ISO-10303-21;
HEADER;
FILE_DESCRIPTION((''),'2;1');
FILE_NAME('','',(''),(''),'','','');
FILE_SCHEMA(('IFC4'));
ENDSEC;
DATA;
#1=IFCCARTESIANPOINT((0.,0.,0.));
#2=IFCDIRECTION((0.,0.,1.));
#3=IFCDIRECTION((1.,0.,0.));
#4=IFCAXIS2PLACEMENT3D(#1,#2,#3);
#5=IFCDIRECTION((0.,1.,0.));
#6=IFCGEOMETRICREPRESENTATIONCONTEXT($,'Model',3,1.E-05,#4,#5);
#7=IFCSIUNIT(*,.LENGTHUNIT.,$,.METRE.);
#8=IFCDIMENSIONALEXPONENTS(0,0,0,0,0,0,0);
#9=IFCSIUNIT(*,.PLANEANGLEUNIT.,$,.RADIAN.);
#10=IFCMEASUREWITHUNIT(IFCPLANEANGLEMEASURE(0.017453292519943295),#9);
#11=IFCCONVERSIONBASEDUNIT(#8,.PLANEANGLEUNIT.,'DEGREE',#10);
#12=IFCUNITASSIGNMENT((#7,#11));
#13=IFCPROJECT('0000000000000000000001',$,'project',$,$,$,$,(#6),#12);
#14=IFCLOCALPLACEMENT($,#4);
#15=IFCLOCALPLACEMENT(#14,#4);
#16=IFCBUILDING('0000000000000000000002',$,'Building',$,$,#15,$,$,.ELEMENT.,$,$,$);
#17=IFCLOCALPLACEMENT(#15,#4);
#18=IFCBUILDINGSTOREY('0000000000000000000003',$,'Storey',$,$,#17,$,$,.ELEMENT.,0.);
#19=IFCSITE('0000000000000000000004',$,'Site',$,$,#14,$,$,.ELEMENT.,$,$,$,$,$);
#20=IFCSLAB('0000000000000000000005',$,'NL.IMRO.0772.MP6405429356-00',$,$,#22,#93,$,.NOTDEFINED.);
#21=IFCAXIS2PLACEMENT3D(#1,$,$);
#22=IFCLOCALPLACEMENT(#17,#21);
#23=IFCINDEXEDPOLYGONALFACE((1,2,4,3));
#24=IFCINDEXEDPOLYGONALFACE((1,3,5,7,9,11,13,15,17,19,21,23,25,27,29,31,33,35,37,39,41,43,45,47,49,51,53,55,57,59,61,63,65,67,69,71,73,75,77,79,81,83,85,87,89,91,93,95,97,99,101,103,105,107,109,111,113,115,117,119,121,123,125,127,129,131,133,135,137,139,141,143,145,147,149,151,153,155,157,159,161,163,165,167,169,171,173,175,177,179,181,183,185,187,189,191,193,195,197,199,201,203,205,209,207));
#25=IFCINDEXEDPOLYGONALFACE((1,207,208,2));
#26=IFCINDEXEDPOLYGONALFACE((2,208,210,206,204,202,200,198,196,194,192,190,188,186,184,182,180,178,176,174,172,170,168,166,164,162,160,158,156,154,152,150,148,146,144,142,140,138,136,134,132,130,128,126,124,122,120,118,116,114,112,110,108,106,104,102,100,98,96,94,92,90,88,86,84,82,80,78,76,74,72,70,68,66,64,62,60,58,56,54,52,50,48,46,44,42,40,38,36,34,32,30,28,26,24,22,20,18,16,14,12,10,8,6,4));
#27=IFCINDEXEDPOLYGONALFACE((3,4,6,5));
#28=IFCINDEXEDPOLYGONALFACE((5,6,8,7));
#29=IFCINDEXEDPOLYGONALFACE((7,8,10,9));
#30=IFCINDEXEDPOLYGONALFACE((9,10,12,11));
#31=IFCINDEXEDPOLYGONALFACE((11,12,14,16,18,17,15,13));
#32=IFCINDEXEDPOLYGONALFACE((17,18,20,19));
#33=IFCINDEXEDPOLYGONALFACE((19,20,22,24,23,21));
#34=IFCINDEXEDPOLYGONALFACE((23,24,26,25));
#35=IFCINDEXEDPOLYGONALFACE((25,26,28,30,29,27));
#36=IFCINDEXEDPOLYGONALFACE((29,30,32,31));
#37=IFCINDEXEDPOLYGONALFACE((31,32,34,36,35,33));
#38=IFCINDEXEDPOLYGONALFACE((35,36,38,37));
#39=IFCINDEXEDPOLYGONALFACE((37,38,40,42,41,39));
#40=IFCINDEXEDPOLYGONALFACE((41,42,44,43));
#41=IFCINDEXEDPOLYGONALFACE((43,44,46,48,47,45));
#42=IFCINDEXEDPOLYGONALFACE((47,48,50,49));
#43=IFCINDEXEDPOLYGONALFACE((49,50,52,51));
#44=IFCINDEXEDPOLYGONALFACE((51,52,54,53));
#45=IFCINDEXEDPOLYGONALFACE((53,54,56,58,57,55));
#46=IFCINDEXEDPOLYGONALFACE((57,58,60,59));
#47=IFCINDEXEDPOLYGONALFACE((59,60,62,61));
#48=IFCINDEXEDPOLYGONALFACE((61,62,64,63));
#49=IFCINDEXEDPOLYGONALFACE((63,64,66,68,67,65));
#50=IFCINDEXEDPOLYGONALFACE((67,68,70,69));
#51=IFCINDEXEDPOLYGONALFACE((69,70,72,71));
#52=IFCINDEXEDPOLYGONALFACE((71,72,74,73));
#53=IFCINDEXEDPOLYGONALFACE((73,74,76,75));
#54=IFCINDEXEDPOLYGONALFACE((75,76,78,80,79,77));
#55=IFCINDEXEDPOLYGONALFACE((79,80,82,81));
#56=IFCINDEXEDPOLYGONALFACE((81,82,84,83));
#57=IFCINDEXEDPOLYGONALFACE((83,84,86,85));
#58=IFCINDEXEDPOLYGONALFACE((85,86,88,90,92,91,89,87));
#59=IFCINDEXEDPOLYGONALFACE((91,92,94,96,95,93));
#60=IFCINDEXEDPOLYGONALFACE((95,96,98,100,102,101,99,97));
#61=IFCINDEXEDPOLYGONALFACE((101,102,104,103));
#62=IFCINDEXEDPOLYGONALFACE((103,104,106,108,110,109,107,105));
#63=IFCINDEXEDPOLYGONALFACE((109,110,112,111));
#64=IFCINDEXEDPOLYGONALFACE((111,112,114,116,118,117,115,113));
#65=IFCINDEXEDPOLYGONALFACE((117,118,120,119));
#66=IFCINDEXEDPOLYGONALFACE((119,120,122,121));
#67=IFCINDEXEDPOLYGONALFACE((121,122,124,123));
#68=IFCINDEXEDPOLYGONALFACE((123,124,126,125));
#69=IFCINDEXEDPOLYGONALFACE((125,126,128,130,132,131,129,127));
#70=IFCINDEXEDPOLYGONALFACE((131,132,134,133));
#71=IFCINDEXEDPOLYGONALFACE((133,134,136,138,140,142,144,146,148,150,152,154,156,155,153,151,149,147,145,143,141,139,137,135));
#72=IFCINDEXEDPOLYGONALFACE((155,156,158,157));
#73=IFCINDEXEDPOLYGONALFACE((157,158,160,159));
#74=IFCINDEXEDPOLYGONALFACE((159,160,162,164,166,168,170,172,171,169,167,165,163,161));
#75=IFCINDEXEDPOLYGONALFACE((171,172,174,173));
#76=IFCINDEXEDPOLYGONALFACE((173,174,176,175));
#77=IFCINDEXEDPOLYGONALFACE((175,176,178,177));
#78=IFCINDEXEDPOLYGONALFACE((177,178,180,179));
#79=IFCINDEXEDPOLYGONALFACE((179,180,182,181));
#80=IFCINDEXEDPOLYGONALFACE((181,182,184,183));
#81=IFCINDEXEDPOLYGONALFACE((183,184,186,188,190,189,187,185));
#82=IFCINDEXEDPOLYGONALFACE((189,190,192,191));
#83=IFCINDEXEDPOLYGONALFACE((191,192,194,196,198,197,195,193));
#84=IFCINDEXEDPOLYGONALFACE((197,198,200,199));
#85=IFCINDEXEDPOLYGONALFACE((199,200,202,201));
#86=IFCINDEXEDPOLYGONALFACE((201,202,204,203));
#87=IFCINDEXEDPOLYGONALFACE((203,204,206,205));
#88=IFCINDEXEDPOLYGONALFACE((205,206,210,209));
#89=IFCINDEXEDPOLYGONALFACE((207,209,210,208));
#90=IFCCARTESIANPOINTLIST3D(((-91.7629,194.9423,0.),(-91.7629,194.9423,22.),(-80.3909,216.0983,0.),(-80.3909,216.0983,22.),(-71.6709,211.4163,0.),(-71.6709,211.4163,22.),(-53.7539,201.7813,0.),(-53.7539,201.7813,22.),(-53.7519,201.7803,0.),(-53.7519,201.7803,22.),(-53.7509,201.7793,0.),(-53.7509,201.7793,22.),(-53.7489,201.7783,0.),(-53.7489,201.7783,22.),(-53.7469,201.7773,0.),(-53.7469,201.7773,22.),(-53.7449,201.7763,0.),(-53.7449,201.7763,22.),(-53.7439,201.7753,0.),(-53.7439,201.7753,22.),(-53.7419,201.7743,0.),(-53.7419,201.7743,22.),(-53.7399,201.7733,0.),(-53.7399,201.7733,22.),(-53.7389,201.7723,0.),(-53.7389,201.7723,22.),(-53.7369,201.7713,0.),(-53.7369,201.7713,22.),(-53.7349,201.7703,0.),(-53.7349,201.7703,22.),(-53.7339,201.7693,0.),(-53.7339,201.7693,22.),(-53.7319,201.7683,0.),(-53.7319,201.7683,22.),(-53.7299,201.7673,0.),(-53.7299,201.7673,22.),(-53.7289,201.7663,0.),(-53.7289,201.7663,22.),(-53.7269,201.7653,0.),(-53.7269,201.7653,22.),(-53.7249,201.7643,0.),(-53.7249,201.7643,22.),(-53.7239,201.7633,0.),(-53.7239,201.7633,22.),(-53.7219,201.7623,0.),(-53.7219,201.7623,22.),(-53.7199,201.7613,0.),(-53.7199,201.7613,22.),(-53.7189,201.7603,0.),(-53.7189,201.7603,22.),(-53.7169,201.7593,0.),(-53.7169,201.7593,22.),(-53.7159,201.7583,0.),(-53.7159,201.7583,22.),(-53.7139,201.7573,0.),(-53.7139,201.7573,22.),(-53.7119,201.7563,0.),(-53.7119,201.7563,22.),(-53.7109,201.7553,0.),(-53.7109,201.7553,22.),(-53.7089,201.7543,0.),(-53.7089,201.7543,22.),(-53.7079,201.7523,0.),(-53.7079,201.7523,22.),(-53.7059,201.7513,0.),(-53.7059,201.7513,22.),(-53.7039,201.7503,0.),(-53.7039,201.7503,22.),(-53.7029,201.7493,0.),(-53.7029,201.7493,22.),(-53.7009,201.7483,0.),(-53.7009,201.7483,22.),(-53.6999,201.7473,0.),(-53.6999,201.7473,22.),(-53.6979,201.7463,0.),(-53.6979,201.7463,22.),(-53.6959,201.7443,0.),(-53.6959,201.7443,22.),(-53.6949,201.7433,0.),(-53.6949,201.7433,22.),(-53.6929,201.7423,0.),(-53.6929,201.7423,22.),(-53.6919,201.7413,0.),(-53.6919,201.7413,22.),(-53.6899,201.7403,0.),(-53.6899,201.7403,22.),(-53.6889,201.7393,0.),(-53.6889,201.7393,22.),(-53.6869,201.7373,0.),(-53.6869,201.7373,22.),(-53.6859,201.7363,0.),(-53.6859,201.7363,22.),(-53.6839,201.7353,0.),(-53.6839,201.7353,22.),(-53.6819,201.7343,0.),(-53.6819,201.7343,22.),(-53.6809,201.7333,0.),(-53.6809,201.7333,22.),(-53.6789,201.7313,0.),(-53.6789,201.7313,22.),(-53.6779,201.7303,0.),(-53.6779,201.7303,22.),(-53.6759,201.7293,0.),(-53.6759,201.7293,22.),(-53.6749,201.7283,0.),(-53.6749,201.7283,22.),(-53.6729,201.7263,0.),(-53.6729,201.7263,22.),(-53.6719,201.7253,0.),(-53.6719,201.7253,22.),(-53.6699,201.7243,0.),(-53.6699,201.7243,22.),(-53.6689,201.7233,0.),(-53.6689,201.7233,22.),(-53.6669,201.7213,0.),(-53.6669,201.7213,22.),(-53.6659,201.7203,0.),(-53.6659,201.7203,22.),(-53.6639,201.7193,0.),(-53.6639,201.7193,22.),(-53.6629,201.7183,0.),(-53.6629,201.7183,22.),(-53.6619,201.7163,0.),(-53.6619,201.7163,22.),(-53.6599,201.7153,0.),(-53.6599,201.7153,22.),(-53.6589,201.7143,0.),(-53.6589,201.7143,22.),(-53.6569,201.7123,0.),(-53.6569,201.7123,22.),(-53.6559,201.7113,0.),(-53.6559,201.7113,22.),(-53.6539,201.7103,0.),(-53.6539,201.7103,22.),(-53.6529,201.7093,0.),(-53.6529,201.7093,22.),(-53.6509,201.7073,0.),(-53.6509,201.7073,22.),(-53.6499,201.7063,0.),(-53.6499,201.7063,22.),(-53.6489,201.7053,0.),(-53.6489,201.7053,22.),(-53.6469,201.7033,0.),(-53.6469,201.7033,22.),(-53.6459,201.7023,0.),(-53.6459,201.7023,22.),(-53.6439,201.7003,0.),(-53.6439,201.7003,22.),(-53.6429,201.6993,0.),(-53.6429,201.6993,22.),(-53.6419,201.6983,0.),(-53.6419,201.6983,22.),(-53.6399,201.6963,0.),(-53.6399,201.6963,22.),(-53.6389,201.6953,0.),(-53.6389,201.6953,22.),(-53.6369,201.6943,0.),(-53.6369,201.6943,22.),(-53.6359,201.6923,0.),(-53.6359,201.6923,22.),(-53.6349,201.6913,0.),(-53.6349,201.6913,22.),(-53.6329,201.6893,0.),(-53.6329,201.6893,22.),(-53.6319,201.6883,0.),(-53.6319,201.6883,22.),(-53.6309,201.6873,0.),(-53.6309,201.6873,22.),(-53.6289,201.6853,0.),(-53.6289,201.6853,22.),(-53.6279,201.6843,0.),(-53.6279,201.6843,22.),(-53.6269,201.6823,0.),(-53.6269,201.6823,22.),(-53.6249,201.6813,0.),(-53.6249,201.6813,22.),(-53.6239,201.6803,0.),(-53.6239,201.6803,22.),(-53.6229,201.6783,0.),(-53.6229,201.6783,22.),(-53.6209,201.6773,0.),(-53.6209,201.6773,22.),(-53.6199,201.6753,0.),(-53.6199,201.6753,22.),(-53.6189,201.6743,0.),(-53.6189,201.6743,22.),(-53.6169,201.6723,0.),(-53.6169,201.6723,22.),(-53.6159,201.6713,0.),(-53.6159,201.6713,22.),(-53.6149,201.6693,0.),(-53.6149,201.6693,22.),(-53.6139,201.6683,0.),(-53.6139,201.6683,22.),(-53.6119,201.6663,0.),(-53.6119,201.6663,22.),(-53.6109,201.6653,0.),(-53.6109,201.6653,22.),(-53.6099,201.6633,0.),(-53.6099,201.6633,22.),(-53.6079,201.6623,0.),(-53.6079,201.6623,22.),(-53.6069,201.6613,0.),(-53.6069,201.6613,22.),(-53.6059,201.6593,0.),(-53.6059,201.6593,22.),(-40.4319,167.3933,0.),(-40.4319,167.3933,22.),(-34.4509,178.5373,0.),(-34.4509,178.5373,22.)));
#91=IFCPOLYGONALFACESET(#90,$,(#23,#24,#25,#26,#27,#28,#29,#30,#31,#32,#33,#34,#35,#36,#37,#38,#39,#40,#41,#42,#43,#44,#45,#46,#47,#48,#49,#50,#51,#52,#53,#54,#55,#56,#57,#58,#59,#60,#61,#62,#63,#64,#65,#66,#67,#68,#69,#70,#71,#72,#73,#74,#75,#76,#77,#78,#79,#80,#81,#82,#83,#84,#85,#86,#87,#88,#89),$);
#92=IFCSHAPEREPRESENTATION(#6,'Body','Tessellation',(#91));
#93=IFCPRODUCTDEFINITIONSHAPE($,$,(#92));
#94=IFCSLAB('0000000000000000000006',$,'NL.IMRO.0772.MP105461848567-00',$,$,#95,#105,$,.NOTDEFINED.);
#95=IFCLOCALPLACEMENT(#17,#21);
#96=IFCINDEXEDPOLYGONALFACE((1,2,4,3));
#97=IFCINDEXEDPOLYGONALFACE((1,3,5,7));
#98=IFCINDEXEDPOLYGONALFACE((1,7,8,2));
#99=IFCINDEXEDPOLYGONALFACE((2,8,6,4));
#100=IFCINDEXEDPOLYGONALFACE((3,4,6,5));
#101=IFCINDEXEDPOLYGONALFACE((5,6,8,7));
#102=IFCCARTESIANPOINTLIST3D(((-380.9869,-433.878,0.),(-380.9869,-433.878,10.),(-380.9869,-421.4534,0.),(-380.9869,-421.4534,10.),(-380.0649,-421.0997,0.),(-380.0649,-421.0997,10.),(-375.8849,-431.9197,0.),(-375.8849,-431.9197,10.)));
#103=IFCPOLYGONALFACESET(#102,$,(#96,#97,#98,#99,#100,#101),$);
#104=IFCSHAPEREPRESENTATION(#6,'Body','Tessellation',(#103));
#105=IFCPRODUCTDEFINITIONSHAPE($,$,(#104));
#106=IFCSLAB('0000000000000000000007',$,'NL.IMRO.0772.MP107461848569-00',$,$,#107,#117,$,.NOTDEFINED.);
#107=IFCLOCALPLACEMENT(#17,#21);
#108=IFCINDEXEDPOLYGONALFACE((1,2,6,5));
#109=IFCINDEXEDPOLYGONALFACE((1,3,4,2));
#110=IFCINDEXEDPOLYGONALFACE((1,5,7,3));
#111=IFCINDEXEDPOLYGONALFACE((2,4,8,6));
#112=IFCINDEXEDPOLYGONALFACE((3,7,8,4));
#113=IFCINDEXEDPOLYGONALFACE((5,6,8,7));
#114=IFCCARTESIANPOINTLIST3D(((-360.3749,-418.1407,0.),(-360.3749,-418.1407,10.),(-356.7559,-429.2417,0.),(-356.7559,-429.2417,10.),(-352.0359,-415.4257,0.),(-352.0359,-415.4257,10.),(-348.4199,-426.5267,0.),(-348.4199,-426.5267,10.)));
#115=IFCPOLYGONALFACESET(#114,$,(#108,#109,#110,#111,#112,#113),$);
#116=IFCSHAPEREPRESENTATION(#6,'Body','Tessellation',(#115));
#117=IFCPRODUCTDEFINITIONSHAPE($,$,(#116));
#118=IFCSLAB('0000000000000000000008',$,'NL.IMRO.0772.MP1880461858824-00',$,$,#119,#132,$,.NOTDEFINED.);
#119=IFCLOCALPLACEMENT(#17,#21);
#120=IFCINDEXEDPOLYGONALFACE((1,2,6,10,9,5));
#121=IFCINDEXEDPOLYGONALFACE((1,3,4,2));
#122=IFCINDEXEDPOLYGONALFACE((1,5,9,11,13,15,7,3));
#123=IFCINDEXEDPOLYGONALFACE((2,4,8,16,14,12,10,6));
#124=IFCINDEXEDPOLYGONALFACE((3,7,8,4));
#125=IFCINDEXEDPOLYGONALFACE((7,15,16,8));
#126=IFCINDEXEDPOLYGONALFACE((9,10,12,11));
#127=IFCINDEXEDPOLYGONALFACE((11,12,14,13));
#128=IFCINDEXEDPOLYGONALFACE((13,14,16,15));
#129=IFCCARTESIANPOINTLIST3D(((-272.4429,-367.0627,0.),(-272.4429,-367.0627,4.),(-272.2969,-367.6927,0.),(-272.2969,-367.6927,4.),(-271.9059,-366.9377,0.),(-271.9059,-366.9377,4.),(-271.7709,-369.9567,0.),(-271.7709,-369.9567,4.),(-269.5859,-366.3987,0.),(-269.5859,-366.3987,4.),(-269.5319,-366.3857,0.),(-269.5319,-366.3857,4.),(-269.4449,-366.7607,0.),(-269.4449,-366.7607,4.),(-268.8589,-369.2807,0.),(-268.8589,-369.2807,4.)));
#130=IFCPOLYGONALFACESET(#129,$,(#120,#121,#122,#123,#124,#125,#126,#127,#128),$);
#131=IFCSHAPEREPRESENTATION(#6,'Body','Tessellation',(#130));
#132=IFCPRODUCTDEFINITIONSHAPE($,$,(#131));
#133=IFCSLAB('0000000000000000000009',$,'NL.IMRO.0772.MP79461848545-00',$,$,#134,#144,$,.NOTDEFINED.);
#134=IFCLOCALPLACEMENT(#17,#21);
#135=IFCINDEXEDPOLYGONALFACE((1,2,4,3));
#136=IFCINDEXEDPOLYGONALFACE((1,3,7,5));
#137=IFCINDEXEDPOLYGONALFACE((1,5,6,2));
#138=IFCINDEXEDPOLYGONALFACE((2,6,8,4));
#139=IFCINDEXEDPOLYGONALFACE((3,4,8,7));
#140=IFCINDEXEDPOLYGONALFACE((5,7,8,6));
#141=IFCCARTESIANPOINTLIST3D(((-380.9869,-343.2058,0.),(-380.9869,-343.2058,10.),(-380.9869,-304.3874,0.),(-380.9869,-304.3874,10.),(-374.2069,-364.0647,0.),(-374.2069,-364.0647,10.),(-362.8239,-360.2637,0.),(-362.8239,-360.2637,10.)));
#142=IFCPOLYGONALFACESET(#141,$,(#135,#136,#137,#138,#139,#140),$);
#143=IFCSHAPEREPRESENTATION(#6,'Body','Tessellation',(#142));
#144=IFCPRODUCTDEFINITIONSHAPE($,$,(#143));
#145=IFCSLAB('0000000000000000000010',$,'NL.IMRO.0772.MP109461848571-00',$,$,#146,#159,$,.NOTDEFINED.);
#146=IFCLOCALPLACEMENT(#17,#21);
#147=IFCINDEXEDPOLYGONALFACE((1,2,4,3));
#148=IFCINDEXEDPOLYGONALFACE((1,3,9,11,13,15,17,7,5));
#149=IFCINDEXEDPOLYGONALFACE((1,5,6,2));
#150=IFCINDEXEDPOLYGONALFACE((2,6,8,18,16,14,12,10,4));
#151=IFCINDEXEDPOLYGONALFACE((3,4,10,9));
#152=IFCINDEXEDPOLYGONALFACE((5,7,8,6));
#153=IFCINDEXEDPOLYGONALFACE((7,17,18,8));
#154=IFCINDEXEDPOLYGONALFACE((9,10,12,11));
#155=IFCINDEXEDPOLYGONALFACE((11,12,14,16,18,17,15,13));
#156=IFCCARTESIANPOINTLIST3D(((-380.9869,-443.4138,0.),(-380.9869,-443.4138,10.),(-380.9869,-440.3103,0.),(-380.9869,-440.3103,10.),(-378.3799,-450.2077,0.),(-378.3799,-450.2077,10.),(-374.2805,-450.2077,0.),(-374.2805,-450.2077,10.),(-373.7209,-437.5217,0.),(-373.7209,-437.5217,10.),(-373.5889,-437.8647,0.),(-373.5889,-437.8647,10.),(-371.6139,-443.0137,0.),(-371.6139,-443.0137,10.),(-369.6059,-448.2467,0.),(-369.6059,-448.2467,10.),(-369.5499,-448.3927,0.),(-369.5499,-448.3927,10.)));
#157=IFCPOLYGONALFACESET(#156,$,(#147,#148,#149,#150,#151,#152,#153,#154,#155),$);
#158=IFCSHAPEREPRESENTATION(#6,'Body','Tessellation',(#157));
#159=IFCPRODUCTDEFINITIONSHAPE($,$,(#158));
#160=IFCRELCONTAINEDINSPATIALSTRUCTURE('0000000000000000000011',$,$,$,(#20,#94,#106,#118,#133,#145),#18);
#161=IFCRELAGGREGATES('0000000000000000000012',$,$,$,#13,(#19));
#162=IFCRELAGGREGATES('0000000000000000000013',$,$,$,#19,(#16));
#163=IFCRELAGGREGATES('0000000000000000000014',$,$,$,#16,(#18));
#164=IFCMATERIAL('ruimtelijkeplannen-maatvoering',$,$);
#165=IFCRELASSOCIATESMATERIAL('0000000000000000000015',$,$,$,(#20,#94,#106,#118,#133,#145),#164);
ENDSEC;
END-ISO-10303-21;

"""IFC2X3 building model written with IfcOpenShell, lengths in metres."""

from ifc_helpers import new_model, entity, si_unit, converted_unit, direction, origin_with_axes, place, context, project, spatial, polyline, outline, extrude, material, element, save


model = new_model("IFC2X3")

# Units and contexts
model_context = context("Model", 3, precision=1e-05, world=origin_with_axes(), true_north=direction((0.0, 1.0, 0.0)))
ifc_project = project(units=[si_unit("LENGTHUNIT", "METRE"), converted_unit("PLANEANGLEUNIT", "DEGREE", entity("IfcPlaneAngleMeasure", 0.017453292519943295), si_unit("PLANEANGLEUNIT", "RADIAN"), dimensions=[0, 0, 0, 0, 0, 0, 0])], contexts=[model_context])

# Site, building, storey
site_placement = place(None, origin_with_axes())
site = spatial("IfcSite", under=ifc_project, at=site_placement, Name="Site", CompositionType="ELEMENT")
building_placement = place(site_placement, origin_with_axes())
building = spatial("IfcBuilding", under=site, at=building_placement, Name="Building", CompositionType="ELEMENT")
storey_placement = place(building_placement, origin_with_axes())
storey = spatial("IfcBuildingStorey", under=building, at=storey_placement, Name="Storey", CompositionType="ELEMENT", Elevation=0.0)

# Slabs
ifc_material_1 = material(Name="ruimtelijkeplannen-maatvoering")
slab_1_placement = place(storey_placement, origin_with_axes())
element("IfcSlab", 1, at=slab_1_placement, inside=storey, material=ifc_material_1, Name="NL.IMRO.0772.MP6405429356-00", PredefinedType="NOTDEFINED", context=model_context, shape_type="SweptSolid", body=[
    extrude(outline(polyline([(-53.7519, 201.7803), (-53.7509, 201.7793), (-53.7489, 201.7783), (-53.7469, 201.7773), (-53.7449, 201.7763), (-53.7439, 201.7753), (-53.7419, 201.7743), (-53.7399, 201.7733), (-53.7389, 201.7723), (-53.7369, 201.7713), (-53.7349, 201.7703), (-53.7339, 201.7693), (-53.7319, 201.7683), (-53.7299, 201.7673), (-53.7289, 201.7663), (-53.7269, 201.7653), (-53.7249, 201.7643), (-53.7239, 201.7633), (-53.7219, 201.7623), (-53.7199, 201.7613), (-53.7189, 201.7603), (-53.7169, 201.7593), (-53.7159, 201.7583), (-53.7139, 201.7573), (-53.7119, 201.7563), (-53.7109, 201.7553), (-53.7089, 201.7543), (-53.7079, 201.7523), (-53.7059, 201.7513), (-53.7039, 201.7503), (-53.7029, 201.7493), (-53.7009, 201.7483), (-53.6999, 201.7473), (-53.6979, 201.7463), (-53.6959, 201.7443), (-53.6949, 201.7433), (-53.6929, 201.7423), (-53.6919, 201.7413), (-53.6899, 201.7403), (-53.6889, 201.7393), (-53.6869, 201.7373), (-53.6859, 201.7363), (-53.6839, 201.7353), (-53.6819, 201.7343), (-53.6809, 201.7333), (-53.6789, 201.7313), (-53.6779, 201.7303), (-53.6759, 201.7293), (-53.6749, 201.7283), (-53.6729, 201.7263), (-53.6719, 201.7253), (-53.6699, 201.7243), (-53.6689, 201.7233), (-53.6669, 201.7213), (-53.6659, 201.7203), (-53.6639, 201.7193), (-53.6629, 201.7183), (-53.6619, 201.7163), (-53.6599, 201.7153), (-53.6589, 201.7143), (-53.6569, 201.7123), (-53.6559, 201.7113), (-53.6539, 201.7103), (-53.6529, 201.7093), (-53.6509, 201.7073), (-53.6499, 201.7063), (-53.6489, 201.7053), (-53.6469, 201.7033), (-53.6459, 201.7023), (-53.6439, 201.7003), (-53.6429, 201.6993), (-53.6419, 201.6983), (-53.6399, 201.6963), (-53.6389, 201.6953), (-53.6369, 201.6943), (-53.6359, 201.6923), (-53.6349, 201.6913), (-53.6329, 201.6893), (-53.6319, 201.6883), (-53.6309, 201.6873), (-53.6289, 201.6853), (-53.6279, 201.6843), (-53.6269, 201.6823), (-53.6249, 201.6813), (-53.6239, 201.6803), (-53.6229, 201.6783), (-53.6209, 201.6773), (-53.6199, 201.6753), (-53.6189, 201.6743), (-53.6169, 201.6723), (-53.6159, 201.6713), (-53.6149, 201.6693), (-53.6139, 201.6683), (-53.6119, 201.6663), (-53.6109, 201.6653), (-53.6099, 201.6633), (-53.6079, 201.6623), (-53.6069, 201.6613), (-53.6059, 201.6593), (-34.4509, 178.5373), (-40.4319, 167.3933), (-91.7629, 194.9423), (-80.3909, 216.0983), (-71.6709, 211.4163), (-53.7539, 201.7813), (-53.7519, 201.7803)])), origin_with_axes(), (0.0, 0.0, 1.0), 22.0),
])
slab_2_placement = place(storey_placement, origin_with_axes())
element("IfcSlab", 2, at=slab_2_placement, inside=storey, material=ifc_material_1, Name="NL.IMRO.0772.MP105461848567-00", PredefinedType="NOTDEFINED", context=model_context, shape_type="SweptSolid", body=[
    extrude(outline(polyline([(-380.0649, -421.0997), (-375.8849, -431.9197), (-380.9869, -433.878), (-380.9869, -421.4534), (-380.0649, -421.0997)])), origin_with_axes(), (0.0, 0.0, 1.0), 10.0),
])
slab_3_placement = place(storey_placement, origin_with_axes())
element("IfcSlab", 3, at=slab_3_placement, inside=storey, material=ifc_material_1, Name="NL.IMRO.0772.MP107461848569-00", PredefinedType="NOTDEFINED", context=model_context, shape_type="SweptSolid", body=[
    extrude(outline(polyline([(-360.3749, -418.1407), (-352.0359, -415.4257), (-348.4199, -426.5267), (-356.7559, -429.2417), (-360.3749, -418.1407)])), origin_with_axes(), (0.0, 0.0, 1.0), 10.0),
])
slab_4_placement = place(storey_placement, origin_with_axes())
element("IfcSlab", 4, at=slab_4_placement, inside=storey, material=ifc_material_1, Name="NL.IMRO.0772.MP1880461858824-00", PredefinedType="NOTDEFINED", context=model_context, shape_type="SweptSolid", body=[
    extrude(outline(polyline([(-271.7709, -369.9567), (-272.2969, -367.6927), (-272.4429, -367.0627), (-271.9059, -366.9377), (-269.5859, -366.3987), (-269.5319, -366.3857), (-269.4449, -366.7607), (-268.8589, -369.2807), (-271.7709, -369.9567)])), origin_with_axes(), (0.0, 0.0, 1.0), 4.0),
])
slab_5_placement = place(storey_placement, origin_with_axes())
element("IfcSlab", 5, at=slab_5_placement, inside=storey, material=ifc_material_1, Name="NL.IMRO.0772.MP79461848545-00", PredefinedType="NOTDEFINED", context=model_context, shape_type="SweptSolid", body=[
    extrude(outline(polyline([(-362.8239, -360.2637), (-374.2069, -364.0647), (-380.9869, -343.2058), (-380.9869, -304.3874), (-362.8239, -360.2637)])), origin_with_axes(), (0.0, 0.0, 1.0), 10.0),
])
slab_6_placement = place(storey_placement, origin_with_axes())
element("IfcSlab", 6, at=slab_6_placement, inside=storey, material=ifc_material_1, Name="NL.IMRO.0772.MP109461848571-00", PredefinedType="NOTDEFINED", context=model_context, shape_type="SweptSolid", body=[
    extrude(outline(polyline([(-373.7209, -437.5217), (-373.5889, -437.8647), (-371.6139, -443.0137), (-369.6059, -448.2467), (-369.5499, -448.3927), (-374.2805, -450.2077), (-378.3799, -450.2077), (-380.9869, -443.4138), (-380.9869, -440.3103), (-373.7209, -437.5217)])), origin_with_axes(), (0.0, 0.0, 1.0), 10.0),
])

save(model, "model.ifc")
